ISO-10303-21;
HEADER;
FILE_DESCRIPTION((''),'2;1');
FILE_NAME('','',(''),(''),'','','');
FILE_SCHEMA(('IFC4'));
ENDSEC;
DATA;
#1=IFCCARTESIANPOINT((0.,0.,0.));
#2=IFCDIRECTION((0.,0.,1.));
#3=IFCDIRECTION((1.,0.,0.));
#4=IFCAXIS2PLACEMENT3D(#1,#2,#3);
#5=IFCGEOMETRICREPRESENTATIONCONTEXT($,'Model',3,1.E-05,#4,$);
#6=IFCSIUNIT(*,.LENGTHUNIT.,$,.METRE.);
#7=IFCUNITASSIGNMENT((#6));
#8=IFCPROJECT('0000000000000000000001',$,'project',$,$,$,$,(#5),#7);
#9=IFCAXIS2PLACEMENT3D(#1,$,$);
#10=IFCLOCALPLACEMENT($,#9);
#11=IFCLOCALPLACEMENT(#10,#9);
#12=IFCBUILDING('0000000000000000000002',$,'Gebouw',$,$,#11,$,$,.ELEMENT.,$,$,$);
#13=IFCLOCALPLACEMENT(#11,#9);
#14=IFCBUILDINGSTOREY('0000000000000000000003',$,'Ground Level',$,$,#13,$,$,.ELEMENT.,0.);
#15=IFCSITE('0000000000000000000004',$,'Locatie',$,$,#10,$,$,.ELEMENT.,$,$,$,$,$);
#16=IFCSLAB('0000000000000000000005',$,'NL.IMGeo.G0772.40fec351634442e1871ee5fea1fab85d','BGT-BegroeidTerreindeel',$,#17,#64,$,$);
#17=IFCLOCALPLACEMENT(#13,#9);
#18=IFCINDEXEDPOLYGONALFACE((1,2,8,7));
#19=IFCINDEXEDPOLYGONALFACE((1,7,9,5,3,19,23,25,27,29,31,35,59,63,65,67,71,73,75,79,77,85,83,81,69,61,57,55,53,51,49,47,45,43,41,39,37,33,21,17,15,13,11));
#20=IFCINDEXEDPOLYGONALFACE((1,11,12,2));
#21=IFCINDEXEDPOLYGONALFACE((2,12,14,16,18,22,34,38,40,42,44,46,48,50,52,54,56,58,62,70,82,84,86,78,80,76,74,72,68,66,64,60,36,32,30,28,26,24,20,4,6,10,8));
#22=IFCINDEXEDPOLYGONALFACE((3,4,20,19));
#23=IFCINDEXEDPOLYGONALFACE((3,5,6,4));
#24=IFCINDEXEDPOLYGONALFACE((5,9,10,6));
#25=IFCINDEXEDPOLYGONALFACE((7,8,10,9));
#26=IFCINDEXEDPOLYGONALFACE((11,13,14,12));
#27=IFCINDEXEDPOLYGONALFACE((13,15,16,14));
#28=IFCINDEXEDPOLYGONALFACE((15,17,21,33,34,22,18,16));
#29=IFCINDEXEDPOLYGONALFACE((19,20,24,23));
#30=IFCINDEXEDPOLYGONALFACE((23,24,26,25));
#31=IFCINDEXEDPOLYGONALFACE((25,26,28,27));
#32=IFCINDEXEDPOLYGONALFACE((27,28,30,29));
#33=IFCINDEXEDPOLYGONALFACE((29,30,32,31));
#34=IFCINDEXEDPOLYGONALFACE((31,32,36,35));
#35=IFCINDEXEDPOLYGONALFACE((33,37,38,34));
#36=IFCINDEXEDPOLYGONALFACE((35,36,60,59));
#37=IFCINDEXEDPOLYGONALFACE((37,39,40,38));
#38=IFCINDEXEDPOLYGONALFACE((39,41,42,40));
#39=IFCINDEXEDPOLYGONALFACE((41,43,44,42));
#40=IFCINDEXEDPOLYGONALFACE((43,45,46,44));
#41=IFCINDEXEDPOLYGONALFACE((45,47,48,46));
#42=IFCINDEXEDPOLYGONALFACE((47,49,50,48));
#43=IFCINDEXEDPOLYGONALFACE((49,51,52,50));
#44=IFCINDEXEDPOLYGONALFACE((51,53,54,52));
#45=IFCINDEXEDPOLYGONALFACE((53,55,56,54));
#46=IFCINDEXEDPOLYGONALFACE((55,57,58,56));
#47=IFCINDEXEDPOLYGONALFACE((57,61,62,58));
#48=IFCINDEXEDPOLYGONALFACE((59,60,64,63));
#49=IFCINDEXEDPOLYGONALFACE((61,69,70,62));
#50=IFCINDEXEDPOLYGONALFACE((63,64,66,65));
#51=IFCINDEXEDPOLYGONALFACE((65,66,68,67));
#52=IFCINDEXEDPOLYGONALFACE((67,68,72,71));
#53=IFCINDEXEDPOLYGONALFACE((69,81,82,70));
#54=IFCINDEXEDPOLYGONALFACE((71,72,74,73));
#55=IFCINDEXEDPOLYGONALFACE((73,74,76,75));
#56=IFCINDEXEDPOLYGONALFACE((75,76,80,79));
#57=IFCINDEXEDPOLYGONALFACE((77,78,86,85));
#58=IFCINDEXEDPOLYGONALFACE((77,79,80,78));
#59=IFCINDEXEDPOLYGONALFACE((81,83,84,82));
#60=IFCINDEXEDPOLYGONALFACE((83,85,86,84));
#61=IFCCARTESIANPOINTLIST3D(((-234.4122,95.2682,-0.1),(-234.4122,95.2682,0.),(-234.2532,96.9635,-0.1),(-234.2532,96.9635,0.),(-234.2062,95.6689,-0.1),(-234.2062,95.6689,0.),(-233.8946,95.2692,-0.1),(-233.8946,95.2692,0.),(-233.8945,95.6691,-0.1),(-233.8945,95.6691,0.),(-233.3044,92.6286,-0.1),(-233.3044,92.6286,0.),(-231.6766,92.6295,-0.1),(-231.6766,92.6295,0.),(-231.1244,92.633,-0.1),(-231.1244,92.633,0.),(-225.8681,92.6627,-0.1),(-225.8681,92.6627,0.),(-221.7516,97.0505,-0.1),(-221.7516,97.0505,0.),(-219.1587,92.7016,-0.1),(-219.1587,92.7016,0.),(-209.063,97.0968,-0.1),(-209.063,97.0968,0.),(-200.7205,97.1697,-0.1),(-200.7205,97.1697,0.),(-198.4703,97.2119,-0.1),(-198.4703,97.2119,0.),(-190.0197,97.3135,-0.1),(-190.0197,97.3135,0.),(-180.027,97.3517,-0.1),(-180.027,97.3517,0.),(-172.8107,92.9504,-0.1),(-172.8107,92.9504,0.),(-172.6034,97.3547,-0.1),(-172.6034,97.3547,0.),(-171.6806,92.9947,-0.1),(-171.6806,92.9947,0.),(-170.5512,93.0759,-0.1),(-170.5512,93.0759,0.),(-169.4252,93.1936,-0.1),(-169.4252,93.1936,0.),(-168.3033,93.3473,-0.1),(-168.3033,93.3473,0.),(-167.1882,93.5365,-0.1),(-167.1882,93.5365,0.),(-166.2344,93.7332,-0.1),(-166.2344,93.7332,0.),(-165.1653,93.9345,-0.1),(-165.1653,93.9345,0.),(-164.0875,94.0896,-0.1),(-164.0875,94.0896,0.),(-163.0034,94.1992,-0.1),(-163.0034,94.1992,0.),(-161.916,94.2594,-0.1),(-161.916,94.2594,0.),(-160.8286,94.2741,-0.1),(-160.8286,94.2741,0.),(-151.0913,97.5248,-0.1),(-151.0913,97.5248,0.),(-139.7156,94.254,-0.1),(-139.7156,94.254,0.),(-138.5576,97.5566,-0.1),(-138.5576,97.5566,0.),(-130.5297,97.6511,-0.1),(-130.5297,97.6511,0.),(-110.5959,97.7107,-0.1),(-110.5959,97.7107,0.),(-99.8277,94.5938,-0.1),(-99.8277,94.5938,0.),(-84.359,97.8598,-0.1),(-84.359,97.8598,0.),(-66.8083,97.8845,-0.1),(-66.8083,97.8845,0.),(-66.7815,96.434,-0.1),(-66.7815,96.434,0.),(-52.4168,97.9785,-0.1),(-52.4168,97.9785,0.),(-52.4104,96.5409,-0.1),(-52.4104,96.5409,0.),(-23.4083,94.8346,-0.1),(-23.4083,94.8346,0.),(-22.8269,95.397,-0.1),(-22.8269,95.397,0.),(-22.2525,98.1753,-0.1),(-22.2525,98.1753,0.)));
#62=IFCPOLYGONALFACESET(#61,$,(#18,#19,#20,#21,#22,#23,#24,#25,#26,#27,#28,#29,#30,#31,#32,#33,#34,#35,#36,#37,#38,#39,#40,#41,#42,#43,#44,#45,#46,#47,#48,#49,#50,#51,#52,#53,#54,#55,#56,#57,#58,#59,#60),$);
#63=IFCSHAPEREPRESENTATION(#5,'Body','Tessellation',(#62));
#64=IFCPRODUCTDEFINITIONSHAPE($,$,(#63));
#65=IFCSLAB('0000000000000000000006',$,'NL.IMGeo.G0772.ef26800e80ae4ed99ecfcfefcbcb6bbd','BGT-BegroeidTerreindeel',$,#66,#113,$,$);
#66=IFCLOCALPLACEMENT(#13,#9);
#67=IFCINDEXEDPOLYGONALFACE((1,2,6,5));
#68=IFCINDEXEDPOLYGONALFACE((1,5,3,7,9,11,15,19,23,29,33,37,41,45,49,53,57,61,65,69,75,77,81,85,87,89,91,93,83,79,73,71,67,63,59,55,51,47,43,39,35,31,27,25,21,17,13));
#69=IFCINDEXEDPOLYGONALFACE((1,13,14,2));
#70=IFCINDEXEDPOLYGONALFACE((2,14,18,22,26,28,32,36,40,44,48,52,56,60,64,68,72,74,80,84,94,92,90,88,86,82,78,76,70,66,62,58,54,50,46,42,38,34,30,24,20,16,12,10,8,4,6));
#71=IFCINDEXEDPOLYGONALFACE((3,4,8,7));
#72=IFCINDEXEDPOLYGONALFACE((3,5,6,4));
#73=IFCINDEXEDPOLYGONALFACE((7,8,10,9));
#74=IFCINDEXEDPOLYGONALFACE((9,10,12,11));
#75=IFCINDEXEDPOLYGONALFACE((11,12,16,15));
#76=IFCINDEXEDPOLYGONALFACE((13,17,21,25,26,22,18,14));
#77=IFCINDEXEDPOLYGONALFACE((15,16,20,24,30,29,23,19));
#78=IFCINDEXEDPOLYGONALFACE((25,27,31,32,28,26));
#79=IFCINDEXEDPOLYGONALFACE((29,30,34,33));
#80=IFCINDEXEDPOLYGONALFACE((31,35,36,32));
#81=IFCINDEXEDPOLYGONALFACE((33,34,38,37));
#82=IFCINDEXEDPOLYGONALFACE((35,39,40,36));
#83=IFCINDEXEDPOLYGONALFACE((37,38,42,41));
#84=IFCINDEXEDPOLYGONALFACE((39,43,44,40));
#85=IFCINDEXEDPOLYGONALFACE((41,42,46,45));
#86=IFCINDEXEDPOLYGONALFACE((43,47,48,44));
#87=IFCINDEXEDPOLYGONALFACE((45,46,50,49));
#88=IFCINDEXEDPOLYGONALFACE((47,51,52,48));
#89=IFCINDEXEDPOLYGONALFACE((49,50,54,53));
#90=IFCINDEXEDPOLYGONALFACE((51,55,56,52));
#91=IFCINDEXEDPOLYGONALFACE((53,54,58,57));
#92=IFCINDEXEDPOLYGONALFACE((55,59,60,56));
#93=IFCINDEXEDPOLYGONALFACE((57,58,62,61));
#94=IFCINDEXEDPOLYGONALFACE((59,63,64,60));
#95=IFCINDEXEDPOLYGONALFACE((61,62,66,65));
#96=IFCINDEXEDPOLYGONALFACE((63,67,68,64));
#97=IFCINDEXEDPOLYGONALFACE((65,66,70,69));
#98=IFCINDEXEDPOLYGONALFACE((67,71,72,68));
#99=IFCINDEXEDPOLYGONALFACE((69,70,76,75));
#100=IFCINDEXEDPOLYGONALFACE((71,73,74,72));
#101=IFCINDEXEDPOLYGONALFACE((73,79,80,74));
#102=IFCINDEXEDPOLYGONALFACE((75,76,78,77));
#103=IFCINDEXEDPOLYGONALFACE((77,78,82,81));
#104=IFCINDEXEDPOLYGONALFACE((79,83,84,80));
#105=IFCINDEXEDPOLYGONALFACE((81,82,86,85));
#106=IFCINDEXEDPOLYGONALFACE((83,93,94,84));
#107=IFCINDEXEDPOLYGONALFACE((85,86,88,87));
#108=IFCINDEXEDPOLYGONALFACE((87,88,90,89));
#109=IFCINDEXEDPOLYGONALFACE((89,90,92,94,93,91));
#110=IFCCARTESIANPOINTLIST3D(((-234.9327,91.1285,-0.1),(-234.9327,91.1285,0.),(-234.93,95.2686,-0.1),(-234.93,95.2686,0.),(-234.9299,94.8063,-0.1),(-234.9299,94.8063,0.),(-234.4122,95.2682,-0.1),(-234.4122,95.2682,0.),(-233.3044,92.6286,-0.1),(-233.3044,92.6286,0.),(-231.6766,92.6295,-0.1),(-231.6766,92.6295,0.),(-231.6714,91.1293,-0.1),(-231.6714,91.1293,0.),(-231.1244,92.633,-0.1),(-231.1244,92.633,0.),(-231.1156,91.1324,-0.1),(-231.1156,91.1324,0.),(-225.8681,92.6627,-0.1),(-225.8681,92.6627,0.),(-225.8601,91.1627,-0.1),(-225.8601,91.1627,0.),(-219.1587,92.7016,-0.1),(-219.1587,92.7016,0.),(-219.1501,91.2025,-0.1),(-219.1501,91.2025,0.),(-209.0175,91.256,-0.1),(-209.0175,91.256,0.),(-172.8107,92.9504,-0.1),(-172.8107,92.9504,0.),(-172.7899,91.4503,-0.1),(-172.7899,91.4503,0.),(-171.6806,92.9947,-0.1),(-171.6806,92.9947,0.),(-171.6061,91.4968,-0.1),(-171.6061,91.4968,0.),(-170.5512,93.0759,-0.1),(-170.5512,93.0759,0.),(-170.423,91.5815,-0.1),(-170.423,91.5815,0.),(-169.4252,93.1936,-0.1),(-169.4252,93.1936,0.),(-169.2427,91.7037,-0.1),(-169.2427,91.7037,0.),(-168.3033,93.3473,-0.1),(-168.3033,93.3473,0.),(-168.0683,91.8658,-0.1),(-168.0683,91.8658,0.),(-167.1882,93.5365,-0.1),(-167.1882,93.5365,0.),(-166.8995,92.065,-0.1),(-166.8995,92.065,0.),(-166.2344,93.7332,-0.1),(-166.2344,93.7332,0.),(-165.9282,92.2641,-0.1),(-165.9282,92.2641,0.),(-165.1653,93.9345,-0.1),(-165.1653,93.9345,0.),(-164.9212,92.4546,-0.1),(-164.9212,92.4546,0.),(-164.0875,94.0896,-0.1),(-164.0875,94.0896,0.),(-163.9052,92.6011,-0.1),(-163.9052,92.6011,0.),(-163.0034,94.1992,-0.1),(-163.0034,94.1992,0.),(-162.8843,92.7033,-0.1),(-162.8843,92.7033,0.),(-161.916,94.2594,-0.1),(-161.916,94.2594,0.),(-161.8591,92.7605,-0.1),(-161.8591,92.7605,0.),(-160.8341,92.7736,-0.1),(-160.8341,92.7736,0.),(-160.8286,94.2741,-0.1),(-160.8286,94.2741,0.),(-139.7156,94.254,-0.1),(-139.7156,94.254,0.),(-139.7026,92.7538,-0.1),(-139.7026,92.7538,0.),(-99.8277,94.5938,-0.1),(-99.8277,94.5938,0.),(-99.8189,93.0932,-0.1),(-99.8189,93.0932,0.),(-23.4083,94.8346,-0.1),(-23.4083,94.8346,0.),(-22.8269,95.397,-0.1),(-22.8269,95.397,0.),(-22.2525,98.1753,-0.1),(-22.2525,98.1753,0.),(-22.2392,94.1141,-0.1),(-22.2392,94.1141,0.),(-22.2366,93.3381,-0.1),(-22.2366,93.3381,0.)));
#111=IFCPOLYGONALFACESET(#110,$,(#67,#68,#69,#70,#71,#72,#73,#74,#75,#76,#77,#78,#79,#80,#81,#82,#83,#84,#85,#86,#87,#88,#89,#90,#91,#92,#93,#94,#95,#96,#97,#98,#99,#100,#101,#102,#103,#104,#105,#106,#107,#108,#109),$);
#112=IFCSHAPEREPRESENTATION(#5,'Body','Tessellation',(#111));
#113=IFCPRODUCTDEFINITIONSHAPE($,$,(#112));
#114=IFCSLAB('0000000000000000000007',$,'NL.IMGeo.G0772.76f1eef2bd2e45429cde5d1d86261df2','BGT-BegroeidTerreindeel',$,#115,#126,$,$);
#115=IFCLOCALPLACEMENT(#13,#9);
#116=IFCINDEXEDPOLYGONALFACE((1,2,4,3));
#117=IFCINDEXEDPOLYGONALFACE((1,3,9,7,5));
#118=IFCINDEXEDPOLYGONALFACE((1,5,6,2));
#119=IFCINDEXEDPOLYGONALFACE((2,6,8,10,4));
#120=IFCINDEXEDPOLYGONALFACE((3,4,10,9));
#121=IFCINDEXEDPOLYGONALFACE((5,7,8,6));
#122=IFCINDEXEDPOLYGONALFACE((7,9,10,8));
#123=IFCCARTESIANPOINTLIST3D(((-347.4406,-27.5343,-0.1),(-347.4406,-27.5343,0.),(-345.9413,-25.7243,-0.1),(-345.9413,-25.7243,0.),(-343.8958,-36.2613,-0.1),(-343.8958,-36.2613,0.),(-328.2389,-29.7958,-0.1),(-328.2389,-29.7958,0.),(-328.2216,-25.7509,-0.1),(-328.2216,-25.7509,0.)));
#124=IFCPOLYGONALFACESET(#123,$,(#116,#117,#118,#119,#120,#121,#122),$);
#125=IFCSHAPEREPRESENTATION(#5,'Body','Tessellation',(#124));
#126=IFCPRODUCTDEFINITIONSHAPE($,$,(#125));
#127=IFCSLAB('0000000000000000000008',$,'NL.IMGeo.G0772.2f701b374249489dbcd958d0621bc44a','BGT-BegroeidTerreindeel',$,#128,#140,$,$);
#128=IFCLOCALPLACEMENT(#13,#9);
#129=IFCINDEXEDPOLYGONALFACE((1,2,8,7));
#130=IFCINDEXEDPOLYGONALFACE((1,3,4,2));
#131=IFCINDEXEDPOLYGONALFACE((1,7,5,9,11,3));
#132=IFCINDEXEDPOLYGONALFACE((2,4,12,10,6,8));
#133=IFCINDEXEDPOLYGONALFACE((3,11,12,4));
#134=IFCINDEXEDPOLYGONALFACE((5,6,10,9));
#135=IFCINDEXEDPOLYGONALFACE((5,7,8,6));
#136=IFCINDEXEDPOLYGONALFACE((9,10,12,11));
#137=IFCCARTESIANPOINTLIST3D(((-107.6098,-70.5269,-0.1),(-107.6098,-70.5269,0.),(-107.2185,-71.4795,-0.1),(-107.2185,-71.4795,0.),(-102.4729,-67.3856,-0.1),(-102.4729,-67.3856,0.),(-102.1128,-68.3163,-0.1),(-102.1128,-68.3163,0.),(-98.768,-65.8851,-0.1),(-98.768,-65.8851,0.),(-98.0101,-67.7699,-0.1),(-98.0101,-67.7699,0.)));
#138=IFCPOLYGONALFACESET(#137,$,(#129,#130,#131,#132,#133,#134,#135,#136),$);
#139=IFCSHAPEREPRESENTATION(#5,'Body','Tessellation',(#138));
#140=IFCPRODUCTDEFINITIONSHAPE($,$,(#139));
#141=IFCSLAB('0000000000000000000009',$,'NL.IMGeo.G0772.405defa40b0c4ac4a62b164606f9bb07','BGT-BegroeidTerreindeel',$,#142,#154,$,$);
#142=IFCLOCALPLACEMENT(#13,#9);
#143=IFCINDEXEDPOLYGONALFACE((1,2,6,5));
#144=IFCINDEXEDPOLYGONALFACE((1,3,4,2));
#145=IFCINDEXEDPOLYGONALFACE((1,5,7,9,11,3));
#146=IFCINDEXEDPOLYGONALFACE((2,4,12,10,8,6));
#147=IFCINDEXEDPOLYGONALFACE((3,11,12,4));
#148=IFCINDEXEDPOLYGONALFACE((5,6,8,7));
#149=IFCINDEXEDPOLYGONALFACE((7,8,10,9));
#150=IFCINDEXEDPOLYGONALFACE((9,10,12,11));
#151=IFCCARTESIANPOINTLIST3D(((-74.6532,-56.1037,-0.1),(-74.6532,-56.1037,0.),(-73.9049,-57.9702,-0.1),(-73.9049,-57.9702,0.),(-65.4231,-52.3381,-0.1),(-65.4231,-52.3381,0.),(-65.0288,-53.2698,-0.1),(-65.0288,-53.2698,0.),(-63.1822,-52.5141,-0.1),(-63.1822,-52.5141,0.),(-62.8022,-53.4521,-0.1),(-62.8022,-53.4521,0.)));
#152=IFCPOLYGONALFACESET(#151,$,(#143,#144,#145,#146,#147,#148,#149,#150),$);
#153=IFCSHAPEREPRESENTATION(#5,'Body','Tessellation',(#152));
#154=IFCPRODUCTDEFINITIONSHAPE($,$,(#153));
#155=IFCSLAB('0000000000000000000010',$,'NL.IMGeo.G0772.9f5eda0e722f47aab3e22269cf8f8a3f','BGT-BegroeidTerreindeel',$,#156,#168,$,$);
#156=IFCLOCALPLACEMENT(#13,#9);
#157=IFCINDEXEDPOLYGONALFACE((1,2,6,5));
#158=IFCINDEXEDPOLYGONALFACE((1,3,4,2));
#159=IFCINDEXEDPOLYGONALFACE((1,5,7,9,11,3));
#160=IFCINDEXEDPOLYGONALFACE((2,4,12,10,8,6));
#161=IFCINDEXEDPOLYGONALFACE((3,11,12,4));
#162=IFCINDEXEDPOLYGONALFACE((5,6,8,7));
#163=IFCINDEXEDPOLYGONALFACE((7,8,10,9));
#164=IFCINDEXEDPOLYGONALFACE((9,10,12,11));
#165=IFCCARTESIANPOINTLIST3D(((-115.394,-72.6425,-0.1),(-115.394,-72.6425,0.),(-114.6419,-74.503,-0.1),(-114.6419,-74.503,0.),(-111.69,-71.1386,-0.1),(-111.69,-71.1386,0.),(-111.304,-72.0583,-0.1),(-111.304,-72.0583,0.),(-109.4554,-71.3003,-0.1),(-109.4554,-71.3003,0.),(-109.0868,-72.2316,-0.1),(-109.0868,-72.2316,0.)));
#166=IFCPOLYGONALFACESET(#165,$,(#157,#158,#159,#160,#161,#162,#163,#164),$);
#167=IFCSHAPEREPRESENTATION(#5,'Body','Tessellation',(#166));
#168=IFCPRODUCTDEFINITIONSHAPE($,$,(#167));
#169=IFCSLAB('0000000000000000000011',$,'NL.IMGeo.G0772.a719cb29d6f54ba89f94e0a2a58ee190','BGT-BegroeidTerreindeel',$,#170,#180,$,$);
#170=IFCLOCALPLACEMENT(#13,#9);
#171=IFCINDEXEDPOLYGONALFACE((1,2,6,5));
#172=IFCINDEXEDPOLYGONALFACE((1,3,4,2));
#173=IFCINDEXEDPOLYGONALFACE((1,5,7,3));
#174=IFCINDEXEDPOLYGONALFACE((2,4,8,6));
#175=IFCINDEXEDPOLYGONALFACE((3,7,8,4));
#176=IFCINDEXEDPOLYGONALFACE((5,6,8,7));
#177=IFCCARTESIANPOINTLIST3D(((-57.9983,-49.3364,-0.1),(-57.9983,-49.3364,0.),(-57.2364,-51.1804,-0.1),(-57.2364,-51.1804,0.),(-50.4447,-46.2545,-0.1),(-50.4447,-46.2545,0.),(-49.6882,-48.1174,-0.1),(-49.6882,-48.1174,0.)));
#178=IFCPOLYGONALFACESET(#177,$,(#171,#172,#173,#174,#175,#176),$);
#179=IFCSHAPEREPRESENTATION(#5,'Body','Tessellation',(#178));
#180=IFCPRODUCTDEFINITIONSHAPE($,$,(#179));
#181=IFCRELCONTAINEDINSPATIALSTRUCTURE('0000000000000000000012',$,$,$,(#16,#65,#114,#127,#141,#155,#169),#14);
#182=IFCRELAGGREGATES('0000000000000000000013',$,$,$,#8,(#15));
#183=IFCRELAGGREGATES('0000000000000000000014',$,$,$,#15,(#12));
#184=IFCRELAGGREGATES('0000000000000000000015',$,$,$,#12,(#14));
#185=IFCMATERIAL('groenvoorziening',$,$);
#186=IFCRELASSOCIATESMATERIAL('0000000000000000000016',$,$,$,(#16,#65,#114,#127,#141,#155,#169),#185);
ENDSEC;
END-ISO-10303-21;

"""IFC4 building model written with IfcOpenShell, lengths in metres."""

from ifc_helpers import new_model, si_unit, frame, origin, origin_with_axes, place, context, project, spatial, polyline, outline, extrude, material, element, save


model = new_model("IFC4")

# Units and contexts
model_context = context("Model", 3, precision=1e-05, world=origin_with_axes())
ifc_project = project(units=[si_unit("LENGTHUNIT", "METRE")], contexts=[model_context])

# Site, building, storey
site_placement = place(None, origin())
site = spatial("IfcSite", under=ifc_project, at=site_placement, Name="Locatie", CompositionType="ELEMENT")
building_placement = place(site_placement, origin())
building = spatial("IfcBuilding", under=site, at=building_placement, Name="Gebouw", CompositionType="ELEMENT")
storey_placement = place(building_placement, origin())
storey = spatial("IfcBuildingStorey", under=building, at=storey_placement, Name="Ground Level", CompositionType="ELEMENT", Elevation=0.0)

# Slabs
ifc_material = material(Name="groenvoorziening")
slab_1_placement = place(storey_placement, origin())
element("IfcSlab", 1, at=slab_1_placement, inside=storey, material=ifc_material, Name="NL.IMGeo.G0772.40fec351634442e1871ee5fea1fab85d", Description="BGT-BegroeidTerreindeel", context=model_context, shape_type="SweptSolid", body=[
    extrude(outline(polyline([(-234.4122, 95.2682), (-233.8946, 95.2692), (-233.8945, 95.6691), (-234.2062, 95.6689), (-234.2532, 96.9635), (-221.7516, 97.0505), (-209.063, 97.0968), (-200.7205, 97.1697), (-198.4703, 97.2119), (-190.0197, 97.3135), (-180.027, 97.3517), (-172.6034, 97.3547), (-151.0913, 97.5248), (-138.5576, 97.5566), (-130.5297, 97.6511), (-110.5959, 97.7107), (-84.359, 97.8598), (-66.8083, 97.8845), (-66.7815, 96.434), (-52.4104, 96.5409), (-52.4168, 97.9785), (-22.2525, 98.1753), (-22.8269, 95.397), (-23.4083, 94.8346), (-99.8277, 94.5938), (-139.7156, 94.254), (-160.8286, 94.2741), (-161.916, 94.2594), (-163.0034, 94.1992), (-164.0875, 94.0896), (-165.1653, 93.9345), (-166.2344, 93.7332), (-167.1882, 93.5365), (-168.3033, 93.3473), (-169.4252, 93.1936), (-170.5512, 93.0759), (-171.6806, 92.9947), (-172.8107, 92.9504), (-219.1587, 92.7016), (-225.8681, 92.6627), (-231.1244, 92.633), (-231.6766, 92.6295), (-233.3044, 92.6286), (-234.4122, 95.2682)])), frame((0.0, 0.0, -0.1), z_axis=(0.0, 0.0, 1.0), x_axis=(1.0, 0.0, 0.0)), (0.0, 0.0, 1.0), 0.1),
])
slab_2_placement = place(storey_placement, origin())
element("IfcSlab", 2, at=slab_2_placement, inside=storey, material=ifc_material, Name="NL.IMGeo.G0772.ef26800e80ae4ed99ecfcfefcbcb6bbd", Description="BGT-BegroeidTerreindeel", context=model_context, shape_type="SweptSolid", body=[
    extrude(outline(polyline([(-234.9299, 94.8063), (-234.93, 95.2686), (-234.4122, 95.2682), (-233.3044, 92.6286), (-231.6766, 92.6295), (-231.1244, 92.633), (-225.8681, 92.6627), (-219.1587, 92.7016), (-172.8107, 92.9504), (-171.6806, 92.9947), (-170.5512, 93.0759), (-169.4252, 93.1936), (-168.3033, 93.3473), (-167.1882, 93.5365), (-166.2344, 93.7332), (-165.1653, 93.9345), (-164.0875, 94.0896), (-163.0034, 94.1992), (-161.916, 94.2594), (-160.8286, 94.2741), (-139.7156, 94.254), (-99.8277, 94.5938), (-23.4083, 94.8346), (-22.8269, 95.397), (-22.2525, 98.1753), (-22.2392, 94.1141), (-22.2366, 93.3381), (-99.8189, 93.0932), (-139.7026, 92.7538), (-160.8341, 92.7736), (-161.8591, 92.7605), (-162.8843, 92.7033), (-163.9052, 92.6011), (-164.9212, 92.4546), (-165.9282, 92.2641), (-166.8995, 92.065), (-168.0683, 91.8658), (-169.2427, 91.7037), (-170.423, 91.5815), (-171.6061, 91.4968), (-172.7899, 91.4503), (-209.0175, 91.256), (-219.1501, 91.2025), (-225.8601, 91.1627), (-231.1156, 91.1324), (-231.6714, 91.1293), (-234.9327, 91.1285), (-234.9299, 94.8063)])), frame((0.0, 0.0, -0.1), z_axis=(0.0, 0.0, 1.0), x_axis=(1.0, 0.0, 0.0)), (0.0, 0.0, 1.0), 0.1),
])
slab_3_placement = place(storey_placement, origin())
element("IfcSlab", 3, at=slab_3_placement, inside=storey, material=ifc_material, Name="NL.IMGeo.G0772.76f1eef2bd2e45429cde5d1d86261df2", Description="BGT-BegroeidTerreindeel", context=model_context, shape_type="SweptSolid", body=[
    extrude(outline(polyline([(-328.2216, -25.7509), (-328.2389, -29.7958), (-343.8958, -36.2613), (-347.4406, -27.5343), (-345.9413, -25.7243), (-328.2216, -25.7509)])), frame((0.0, 0.0, -0.1), z_axis=(0.0, 0.0, 1.0), x_axis=(1.0, 0.0, 0.0)), (0.0, 0.0, 1.0), 0.1),
])
slab_4_placement = place(storey_placement, origin())
element("IfcSlab", 4, at=slab_4_placement, inside=storey, material=ifc_material, Name="NL.IMGeo.G0772.2f701b374249489dbcd958d0621bc44a", Description="BGT-BegroeidTerreindeel", context=model_context, shape_type="SweptSolid", body=[
    extrude(outline(polyline([(-107.6098, -70.5269), (-102.1128, -68.3163), (-102.4729, -67.3856), (-98.768, -65.8851), (-98.0101, -67.7699), (-107.2185, -71.4795), (-107.6098, -70.5269)])), frame((0.0, 0.0, -0.1), z_axis=(0.0, 0.0, 1.0), x_axis=(1.0, 0.0, 0.0)), (0.0, 0.0, 1.0), 0.1),
])
slab_5_placement = place(storey_placement, origin())
element("IfcSlab", 5, at=slab_5_placement, inside=storey, material=ifc_material, Name="NL.IMGeo.G0772.405defa40b0c4ac4a62b164606f9bb07", Description="BGT-BegroeidTerreindeel", context=model_context, shape_type="SweptSolid", body=[
    extrude(outline(polyline([(-65.4231, -52.3381), (-65.0288, -53.2698), (-63.1822, -52.5141), (-62.8022, -53.4521), (-73.9049, -57.9702), (-74.6532, -56.1037), (-65.4231, -52.3381)])), frame((0.0, 0.0, -0.1), z_axis=(0.0, 0.0, 1.0), x_axis=(1.0, 0.0, 0.0)), (0.0, 0.0, 1.0), 0.1),
])
slab_6_placement = place(storey_placement, origin())
element("IfcSlab", 6, at=slab_6_placement, inside=storey, material=ifc_material, Name="NL.IMGeo.G0772.9f5eda0e722f47aab3e22269cf8f8a3f", Description="BGT-BegroeidTerreindeel", context=model_context, shape_type="SweptSolid", body=[
    extrude(outline(polyline([(-111.69, -71.1386), (-111.304, -72.0583), (-109.4554, -71.3003), (-109.0868, -72.2316), (-114.6419, -74.503), (-115.394, -72.6425), (-111.69, -71.1386)])), frame((0.0, 0.0, -0.1), z_axis=(0.0, 0.0, 1.0), x_axis=(1.0, 0.0, 0.0)), (0.0, 0.0, 1.0), 0.1),
])
slab_7_placement = place(storey_placement, origin())
element("IfcSlab", 7, at=slab_7_placement, inside=storey, material=ifc_material, Name="NL.IMGeo.G0772.a719cb29d6f54ba89f94e0a2a58ee190", Description="BGT-BegroeidTerreindeel", context=model_context, shape_type="SweptSolid", body=[
    extrude(outline(polyline([(-57.2364, -51.1804), (-57.9983, -49.3364), (-50.4447, -46.2545), (-49.6882, -48.1174), (-57.2364, -51.1804)])), frame((0.0, 0.0, -0.1), z_axis=(0.0, 0.0, 1.0), x_axis=(1.0, 0.0, 0.0)), (0.0, 0.0, 1.0), 0.1),
])

save(model, "model.ifc")
